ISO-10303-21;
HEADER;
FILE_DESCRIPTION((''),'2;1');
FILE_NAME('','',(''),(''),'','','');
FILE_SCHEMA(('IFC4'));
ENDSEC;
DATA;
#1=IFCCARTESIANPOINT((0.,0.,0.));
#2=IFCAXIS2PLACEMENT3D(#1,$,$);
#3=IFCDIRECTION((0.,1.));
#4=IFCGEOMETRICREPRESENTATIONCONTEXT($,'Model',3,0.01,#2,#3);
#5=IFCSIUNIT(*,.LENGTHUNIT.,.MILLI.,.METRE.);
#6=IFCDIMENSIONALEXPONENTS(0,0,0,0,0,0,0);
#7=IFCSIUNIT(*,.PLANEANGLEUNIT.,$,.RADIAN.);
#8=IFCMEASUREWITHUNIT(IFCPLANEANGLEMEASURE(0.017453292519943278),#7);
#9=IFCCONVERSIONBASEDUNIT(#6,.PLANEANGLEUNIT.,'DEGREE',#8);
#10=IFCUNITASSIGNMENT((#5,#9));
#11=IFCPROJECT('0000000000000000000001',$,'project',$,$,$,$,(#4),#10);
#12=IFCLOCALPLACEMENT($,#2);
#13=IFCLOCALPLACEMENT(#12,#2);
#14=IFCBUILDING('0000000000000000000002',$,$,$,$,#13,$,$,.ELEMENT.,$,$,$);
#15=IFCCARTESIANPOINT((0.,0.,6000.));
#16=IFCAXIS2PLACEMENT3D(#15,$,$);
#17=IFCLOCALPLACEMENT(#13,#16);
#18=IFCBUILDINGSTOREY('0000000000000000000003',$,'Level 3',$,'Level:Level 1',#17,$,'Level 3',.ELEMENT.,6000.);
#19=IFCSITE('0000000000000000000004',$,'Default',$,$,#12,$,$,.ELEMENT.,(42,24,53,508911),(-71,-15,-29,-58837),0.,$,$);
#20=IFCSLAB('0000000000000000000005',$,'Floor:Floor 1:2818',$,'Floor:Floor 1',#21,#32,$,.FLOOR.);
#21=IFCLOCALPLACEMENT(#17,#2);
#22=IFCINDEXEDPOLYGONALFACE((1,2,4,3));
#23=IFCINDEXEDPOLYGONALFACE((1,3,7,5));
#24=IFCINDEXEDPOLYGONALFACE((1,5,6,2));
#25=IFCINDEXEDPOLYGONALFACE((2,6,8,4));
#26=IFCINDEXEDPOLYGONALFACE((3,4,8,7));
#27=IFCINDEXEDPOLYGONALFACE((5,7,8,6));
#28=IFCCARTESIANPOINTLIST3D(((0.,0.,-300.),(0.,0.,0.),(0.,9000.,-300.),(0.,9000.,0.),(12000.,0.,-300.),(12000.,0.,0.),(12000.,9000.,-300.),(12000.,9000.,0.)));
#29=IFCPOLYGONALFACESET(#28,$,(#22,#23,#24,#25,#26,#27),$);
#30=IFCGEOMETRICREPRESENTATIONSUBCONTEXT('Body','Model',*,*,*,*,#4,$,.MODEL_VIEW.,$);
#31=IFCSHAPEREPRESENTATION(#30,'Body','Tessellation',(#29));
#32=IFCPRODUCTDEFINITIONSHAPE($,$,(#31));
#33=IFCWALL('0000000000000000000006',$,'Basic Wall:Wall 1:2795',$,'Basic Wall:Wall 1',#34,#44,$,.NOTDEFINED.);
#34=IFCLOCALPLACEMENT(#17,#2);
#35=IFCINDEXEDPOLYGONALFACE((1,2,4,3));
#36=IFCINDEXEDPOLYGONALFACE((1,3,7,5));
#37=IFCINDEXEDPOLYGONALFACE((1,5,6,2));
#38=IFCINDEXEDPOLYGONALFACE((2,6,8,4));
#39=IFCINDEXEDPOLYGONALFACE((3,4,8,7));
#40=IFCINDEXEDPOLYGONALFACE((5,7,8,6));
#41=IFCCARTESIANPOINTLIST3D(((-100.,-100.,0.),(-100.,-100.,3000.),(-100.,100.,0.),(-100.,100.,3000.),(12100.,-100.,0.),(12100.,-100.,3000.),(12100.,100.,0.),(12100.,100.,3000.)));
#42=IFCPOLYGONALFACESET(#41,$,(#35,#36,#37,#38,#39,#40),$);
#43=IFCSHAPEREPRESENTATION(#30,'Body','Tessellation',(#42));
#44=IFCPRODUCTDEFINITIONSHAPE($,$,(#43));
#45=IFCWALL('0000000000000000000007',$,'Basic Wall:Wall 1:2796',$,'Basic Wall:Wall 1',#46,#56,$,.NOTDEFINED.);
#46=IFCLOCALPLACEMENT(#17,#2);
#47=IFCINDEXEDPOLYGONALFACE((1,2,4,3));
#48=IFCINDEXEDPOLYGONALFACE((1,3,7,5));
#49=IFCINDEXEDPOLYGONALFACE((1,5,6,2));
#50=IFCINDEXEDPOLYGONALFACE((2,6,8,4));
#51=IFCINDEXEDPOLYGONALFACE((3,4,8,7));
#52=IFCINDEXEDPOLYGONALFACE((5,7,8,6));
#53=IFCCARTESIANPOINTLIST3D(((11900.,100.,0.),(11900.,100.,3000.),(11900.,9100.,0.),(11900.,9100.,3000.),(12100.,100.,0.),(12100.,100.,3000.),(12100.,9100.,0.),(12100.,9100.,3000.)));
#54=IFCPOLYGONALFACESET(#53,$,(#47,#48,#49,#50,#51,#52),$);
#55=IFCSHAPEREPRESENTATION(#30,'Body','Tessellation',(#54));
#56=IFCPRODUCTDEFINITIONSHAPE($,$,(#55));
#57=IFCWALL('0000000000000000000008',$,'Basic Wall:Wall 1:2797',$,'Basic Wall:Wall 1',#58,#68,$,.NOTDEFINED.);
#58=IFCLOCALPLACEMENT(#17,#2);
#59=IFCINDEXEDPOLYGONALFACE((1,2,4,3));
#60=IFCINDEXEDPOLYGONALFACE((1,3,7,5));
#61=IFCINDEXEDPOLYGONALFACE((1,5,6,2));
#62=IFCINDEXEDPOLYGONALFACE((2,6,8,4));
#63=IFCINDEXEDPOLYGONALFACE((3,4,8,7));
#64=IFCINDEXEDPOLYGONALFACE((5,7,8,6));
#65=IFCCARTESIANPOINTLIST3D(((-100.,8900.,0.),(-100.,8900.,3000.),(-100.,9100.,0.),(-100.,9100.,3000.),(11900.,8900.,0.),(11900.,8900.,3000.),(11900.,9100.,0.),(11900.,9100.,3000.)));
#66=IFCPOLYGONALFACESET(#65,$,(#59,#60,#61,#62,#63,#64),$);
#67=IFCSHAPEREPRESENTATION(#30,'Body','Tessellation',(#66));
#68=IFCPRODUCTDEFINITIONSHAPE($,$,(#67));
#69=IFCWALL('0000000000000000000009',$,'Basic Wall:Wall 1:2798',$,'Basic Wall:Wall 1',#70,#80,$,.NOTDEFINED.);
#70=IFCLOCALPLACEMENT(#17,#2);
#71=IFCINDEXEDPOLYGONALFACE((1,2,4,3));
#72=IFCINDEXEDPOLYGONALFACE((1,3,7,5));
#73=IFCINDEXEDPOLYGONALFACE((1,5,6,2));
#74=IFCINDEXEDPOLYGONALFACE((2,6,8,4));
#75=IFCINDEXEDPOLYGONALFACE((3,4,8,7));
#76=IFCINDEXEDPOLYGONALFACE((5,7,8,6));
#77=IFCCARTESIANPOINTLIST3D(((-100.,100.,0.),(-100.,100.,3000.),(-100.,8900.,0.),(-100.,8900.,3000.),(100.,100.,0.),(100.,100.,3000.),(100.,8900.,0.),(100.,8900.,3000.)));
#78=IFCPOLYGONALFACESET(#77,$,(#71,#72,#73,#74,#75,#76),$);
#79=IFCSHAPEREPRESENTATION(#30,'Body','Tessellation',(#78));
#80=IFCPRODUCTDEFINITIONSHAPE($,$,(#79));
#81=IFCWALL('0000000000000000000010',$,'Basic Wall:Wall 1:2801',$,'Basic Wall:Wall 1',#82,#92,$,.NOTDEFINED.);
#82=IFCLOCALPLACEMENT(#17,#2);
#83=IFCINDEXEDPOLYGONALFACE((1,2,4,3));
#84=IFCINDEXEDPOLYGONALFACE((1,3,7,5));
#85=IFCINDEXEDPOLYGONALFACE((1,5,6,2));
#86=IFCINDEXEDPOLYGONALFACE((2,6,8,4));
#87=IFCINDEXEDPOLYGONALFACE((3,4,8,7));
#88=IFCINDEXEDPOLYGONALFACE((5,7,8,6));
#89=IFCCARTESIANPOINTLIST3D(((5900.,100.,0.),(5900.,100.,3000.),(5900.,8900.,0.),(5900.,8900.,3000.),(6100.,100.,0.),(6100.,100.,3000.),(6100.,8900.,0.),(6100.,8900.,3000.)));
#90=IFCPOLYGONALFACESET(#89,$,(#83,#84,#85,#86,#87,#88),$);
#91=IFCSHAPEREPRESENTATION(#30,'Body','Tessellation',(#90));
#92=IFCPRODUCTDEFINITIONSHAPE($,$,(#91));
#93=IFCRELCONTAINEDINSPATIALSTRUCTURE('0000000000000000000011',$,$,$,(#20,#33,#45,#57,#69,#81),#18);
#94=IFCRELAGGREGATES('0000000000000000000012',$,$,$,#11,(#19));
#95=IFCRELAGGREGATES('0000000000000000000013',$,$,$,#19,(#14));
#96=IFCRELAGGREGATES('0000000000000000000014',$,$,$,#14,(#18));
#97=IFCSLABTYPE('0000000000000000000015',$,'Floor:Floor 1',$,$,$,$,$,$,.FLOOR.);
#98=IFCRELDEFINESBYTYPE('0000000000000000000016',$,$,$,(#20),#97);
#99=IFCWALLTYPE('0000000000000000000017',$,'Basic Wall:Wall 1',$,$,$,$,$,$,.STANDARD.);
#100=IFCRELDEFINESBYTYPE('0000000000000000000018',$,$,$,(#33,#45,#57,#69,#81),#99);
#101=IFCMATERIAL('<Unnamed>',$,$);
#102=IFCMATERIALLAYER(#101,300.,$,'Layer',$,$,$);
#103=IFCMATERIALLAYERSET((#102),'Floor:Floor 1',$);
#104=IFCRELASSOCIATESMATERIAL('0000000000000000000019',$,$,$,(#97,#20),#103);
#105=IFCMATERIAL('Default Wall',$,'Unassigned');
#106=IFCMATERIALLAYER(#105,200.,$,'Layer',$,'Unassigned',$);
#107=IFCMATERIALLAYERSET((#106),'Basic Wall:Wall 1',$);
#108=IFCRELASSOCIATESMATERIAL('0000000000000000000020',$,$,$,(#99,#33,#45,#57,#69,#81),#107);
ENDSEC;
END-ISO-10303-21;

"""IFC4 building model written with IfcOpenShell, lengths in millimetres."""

from ifc_helpers import new_model, entity, si_unit, converted_unit, direction, frame, frame_2d, origin, origin_2d_with_axis, place, context, subcontext, project, spatial, rectangle, extrude, material, layer, layer_set, layer_usage, type_object, element, save


model = new_model("IFC4")

# Units and contexts
model_context = context("Model", 3, precision=0.01, world=origin(), true_north=direction((0.0, 1.0)))
body_context = subcontext(model_context, "Body", "Model", "MODEL_VIEW")
ifc_project = project(units=[si_unit("LENGTHUNIT", "METRE", prefix="MILLI"), converted_unit("PLANEANGLEUNIT", "DEGREE", entity("IfcPlaneAngleMeasure", 0.017453292519943278), si_unit("PLANEANGLEUNIT", "RADIAN"), dimensions=[0, 0, 0, 0, 0, 0, 0])], contexts=[model_context])

# Site, building, storey
site_placement = place(None, origin())
site = spatial("IfcSite", under=ifc_project, at=site_placement, Name="Default", CompositionType="ELEMENT", RefLatitude=(42, 24, 53, 508911), RefLongitude=(-71, -15, -29, -58837), RefElevation=0.0)
building_placement = place(site_placement, origin())
building = spatial("IfcBuilding", under=site, at=building_placement, CompositionType="ELEMENT")
storey_placement = place(building_placement, frame((0.0, 0.0, 6000.0)))
storey = spatial("IfcBuildingStorey", under=building, at=storey_placement, Name="Level 3", ObjectType="Level:Level 1", LongName="Level 3", CompositionType="ELEMENT", Elevation=6000.0)

# Slab
ifc_material_1 = material(Name="<Unnamed>")
ifc_layer_1 = layer(ifc_material_1, 300.0, Name="Layer")
ifc_layer_set_1 = layer_set([ifc_layer_1], Name="Floor:Floor 1")
ifc_layer_usage_1 = layer_usage(ifc_layer_set_1, "AXIS3", "POSITIVE", 0.0)
slab_type = type_object("IfcSlabType", Name="Floor:Floor 1", PredefinedType="FLOOR", material=ifc_layer_set_1)
slab_placement = place(storey_placement, origin())
element("IfcSlab", 1, at=slab_placement, inside=storey, type_object=slab_type, material=ifc_layer_usage_1, Name="Floor:Floor 1:2818", ObjectType="Floor:Floor 1", PredefinedType="FLOOR", context=body_context, shape_type="SweptSolid", body=[
    extrude(rectangle(XDim=9000.0, YDim=12000.0, at=origin_2d_with_axis()), frame((6000.0, 4500.0, 0.0), z_axis=(0.0, 0.0, -1.0), x_axis=(0.0, 1.0, 0.0)), (0.0, 0.0, 1.0), 300.0),
])

# Walls
ifc_material_2 = material(Name="Default Wall", Category="Unassigned")
ifc_layer_2 = layer(ifc_material_2, 200.0, Name="Layer", Category="Unassigned")
ifc_layer_set_2 = layer_set([ifc_layer_2], Name="Basic Wall:Wall 1")
ifc_layer_usage_2 = layer_usage(ifc_layer_set_2, "AXIS2", "NEGATIVE", 100.0)
wall_type = type_object("IfcWallType", Name="Basic Wall:Wall 1", PredefinedType="STANDARD", material=ifc_layer_set_2)
wall_1_placement = place(storey_placement, frame((-100.0, 0.0, 0.0)))
element("IfcWall", 2, at=wall_1_placement, inside=storey, type_object=wall_type, material=ifc_layer_usage_2, Name="Basic Wall:Wall 1:2795", ObjectType="Basic Wall:Wall 1", PredefinedType="NOTDEFINED", context=body_context, shape_type="SweptSolid", body=[
    extrude(rectangle(XDim=12200.0, YDim=200.0, at=frame_2d((6100.0, 0.0), x_axis=(-1.0, 0.0))), origin(), (0.0, 0.0, 1.0), 3000.0),
])
ifc_layer_usage_3 = layer_usage(ifc_layer_set_2, "AXIS2", "NEGATIVE", 100.0)
wall_2_placement = place(storey_placement, frame((12000.0, 100.0, 0.0), z_axis=(0.0, 0.0, 1.0), x_axis=(0.0, 1.0, 0.0)))
element("IfcWall", 3, at=wall_2_placement, inside=storey, type_object=wall_type, material=ifc_layer_usage_3, Name="Basic Wall:Wall 1:2796", ObjectType="Basic Wall:Wall 1", PredefinedType="NOTDEFINED", context=body_context, shape_type="SweptSolid", body=[
    extrude(rectangle(XDim=9000.0, YDim=200.0, at=frame_2d((4500.0, 0.0), x_axis=(-1.0, 0.0))), origin(), (0.0, 0.0, 1.0), 3000.0),
])
ifc_layer_usage_4 = layer_usage(ifc_layer_set_2, "AXIS2", "NEGATIVE", 100.0)
wall_3_placement = place(storey_placement, frame((11900.0, 9000.0, 0.0), z_axis=(0.0, 0.0, 1.0), x_axis=(-1.0, 0.0, 0.0)))
element("IfcWall", 4, at=wall_3_placement, inside=storey, type_object=wall_type, material=ifc_layer_usage_4, Name="Basic Wall:Wall 1:2797", ObjectType="Basic Wall:Wall 1", PredefinedType="NOTDEFINED", context=body_context, shape_type="SweptSolid", body=[
    extrude(rectangle(XDim=12000.0, YDim=200.0, at=frame_2d((6000.0, 0.0), x_axis=(-1.0, 0.0))), origin(), (0.0, 0.0, 1.0), 3000.0),
])
ifc_layer_usage_5 = layer_usage(ifc_layer_set_2, "AXIS2", "NEGATIVE", 100.0)
wall_4_placement = place(storey_placement, frame((0.0, 8900.0, 0.0), z_axis=(0.0, 0.0, 1.0), x_axis=(0.0, -1.0, 0.0)))
element("IfcWall", 5, at=wall_4_placement, inside=storey, type_object=wall_type, material=ifc_layer_usage_5, Name="Basic Wall:Wall 1:2798", ObjectType="Basic Wall:Wall 1", PredefinedType="NOTDEFINED", context=body_context, shape_type="SweptSolid", body=[
    extrude(rectangle(XDim=8800.0, YDim=200.0, at=frame_2d((4400.0, 0.0), x_axis=(-1.0, 0.0))), origin(), (0.0, 0.0, 1.0), 3000.0),
])
ifc_layer_usage_6 = layer_usage(ifc_layer_set_2, "AXIS2", "NEGATIVE", 100.0)
wall_5_placement = place(storey_placement, frame((6000.0, 100.0, 0.0), z_axis=(0.0, 0.0, 1.0), x_axis=(0.0, 1.0, 0.0)))
element("IfcWall", 6, at=wall_5_placement, inside=storey, type_object=wall_type, material=ifc_layer_usage_6, Name="Basic Wall:Wall 1:2801", ObjectType="Basic Wall:Wall 1", PredefinedType="NOTDEFINED", context=body_context, shape_type="SweptSolid", body=[
    extrude(rectangle(XDim=8800.0, YDim=200.0, at=frame_2d((4400.0, 0.0), x_axis=(-1.0, 0.0))), origin(), (0.0, 0.0, 1.0), 3000.0),
])

save(model, "model.ifc")
